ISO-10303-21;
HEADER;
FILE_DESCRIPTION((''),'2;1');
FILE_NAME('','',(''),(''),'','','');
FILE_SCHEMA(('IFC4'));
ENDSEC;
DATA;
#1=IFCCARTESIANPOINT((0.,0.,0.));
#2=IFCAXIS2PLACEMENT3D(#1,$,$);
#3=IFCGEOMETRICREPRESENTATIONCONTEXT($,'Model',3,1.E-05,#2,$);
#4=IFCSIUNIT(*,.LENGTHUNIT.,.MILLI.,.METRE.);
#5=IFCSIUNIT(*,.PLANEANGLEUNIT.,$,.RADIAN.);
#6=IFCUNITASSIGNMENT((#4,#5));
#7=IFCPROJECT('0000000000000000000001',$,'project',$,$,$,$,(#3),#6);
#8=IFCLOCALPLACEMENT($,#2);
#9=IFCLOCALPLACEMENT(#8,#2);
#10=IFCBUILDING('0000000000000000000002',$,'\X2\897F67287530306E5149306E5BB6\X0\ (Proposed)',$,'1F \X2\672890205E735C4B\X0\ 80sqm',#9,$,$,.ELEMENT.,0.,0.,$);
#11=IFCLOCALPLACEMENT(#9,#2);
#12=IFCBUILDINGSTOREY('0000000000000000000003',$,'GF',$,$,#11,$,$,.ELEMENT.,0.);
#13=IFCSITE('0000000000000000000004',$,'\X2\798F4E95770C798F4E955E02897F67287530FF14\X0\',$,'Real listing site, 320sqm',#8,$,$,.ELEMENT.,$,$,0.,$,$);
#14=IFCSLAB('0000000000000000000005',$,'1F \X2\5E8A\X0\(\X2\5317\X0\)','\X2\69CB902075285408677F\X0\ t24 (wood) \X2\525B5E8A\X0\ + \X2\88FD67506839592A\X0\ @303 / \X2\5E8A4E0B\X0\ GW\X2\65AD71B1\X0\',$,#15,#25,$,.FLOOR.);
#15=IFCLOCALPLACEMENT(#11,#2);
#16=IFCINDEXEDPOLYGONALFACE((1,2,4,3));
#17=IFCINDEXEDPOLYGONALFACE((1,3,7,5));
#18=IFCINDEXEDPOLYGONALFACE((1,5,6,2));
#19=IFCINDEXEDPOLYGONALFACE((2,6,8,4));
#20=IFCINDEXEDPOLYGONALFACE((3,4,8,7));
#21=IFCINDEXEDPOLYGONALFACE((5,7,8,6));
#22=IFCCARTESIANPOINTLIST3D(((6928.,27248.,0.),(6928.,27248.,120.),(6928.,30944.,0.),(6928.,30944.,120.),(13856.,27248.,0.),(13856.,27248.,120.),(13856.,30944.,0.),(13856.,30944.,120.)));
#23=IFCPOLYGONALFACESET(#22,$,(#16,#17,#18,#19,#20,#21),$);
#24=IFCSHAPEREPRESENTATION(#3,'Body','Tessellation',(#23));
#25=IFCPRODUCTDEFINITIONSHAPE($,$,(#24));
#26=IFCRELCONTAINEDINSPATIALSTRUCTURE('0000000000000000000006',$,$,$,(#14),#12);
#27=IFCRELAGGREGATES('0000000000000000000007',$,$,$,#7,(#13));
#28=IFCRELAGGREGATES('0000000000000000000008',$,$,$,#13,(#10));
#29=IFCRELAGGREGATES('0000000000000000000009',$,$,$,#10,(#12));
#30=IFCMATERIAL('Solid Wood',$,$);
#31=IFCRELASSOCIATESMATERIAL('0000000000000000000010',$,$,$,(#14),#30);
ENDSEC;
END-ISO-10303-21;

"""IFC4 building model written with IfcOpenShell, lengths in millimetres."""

from ifc_helpers import new_model, si_unit, frame, frame_2d, origin, place, context, project, spatial, rectangle, extrude, material, element, save


model = new_model("IFC4")

# Units and contexts
model_context = context("Model", 3, precision=1e-05, world=origin())
ifc_project = project(units=[si_unit("LENGTHUNIT", "METRE", prefix="MILLI"), si_unit("PLANEANGLEUNIT", "RADIAN")], contexts=[model_context])

# Site, building, storey
site_placement = place(None, origin())
site = spatial("IfcSite", under=ifc_project, at=site_placement, Name="福井県福井市西木田４", ObjectType="Real listing site, 320sqm", CompositionType="ELEMENT", RefElevation=0.0)
building_placement = place(site_placement, origin())
building = spatial("IfcBuilding", under=site, at=building_placement, Name="西木田の光の家 (Proposed)", ObjectType="1F 木造平屋 80sqm", CompositionType="ELEMENT", ElevationOfRefHeight=0.0, ElevationOfTerrain=0.0)
storey_placement = place(building_placement, origin())
storey = spatial("IfcBuildingStorey", under=building, at=storey_placement, Name="GF", CompositionType="ELEMENT", Elevation=0.0)

# Shared definitions
ifc_material_1 = material(Name="Solid Wood")

# Slab
slab_1_placement = place(storey_placement, frame((3464.0, 13624.0, 0.0)))
element("IfcSlab", 1, at=slab_1_placement, inside=storey, material=ifc_material_1, Name="1F 床(北)", Description="構造用合板 t24 (wood) 剛床 + 製材根太 @303 / 床下 GW断熱", PredefinedType="FLOOR", context=model_context, shape_type="SweptSolid", body=[
    extrude(rectangle(XDim=6928.0, YDim=3696.0, at=frame_2d((3464.0, 1848.0))), frame((3464.0, 13624.0, 0.0)), (0.0, 0.0, 1.0), 120.0),
])

save(model, "model.ifc")
